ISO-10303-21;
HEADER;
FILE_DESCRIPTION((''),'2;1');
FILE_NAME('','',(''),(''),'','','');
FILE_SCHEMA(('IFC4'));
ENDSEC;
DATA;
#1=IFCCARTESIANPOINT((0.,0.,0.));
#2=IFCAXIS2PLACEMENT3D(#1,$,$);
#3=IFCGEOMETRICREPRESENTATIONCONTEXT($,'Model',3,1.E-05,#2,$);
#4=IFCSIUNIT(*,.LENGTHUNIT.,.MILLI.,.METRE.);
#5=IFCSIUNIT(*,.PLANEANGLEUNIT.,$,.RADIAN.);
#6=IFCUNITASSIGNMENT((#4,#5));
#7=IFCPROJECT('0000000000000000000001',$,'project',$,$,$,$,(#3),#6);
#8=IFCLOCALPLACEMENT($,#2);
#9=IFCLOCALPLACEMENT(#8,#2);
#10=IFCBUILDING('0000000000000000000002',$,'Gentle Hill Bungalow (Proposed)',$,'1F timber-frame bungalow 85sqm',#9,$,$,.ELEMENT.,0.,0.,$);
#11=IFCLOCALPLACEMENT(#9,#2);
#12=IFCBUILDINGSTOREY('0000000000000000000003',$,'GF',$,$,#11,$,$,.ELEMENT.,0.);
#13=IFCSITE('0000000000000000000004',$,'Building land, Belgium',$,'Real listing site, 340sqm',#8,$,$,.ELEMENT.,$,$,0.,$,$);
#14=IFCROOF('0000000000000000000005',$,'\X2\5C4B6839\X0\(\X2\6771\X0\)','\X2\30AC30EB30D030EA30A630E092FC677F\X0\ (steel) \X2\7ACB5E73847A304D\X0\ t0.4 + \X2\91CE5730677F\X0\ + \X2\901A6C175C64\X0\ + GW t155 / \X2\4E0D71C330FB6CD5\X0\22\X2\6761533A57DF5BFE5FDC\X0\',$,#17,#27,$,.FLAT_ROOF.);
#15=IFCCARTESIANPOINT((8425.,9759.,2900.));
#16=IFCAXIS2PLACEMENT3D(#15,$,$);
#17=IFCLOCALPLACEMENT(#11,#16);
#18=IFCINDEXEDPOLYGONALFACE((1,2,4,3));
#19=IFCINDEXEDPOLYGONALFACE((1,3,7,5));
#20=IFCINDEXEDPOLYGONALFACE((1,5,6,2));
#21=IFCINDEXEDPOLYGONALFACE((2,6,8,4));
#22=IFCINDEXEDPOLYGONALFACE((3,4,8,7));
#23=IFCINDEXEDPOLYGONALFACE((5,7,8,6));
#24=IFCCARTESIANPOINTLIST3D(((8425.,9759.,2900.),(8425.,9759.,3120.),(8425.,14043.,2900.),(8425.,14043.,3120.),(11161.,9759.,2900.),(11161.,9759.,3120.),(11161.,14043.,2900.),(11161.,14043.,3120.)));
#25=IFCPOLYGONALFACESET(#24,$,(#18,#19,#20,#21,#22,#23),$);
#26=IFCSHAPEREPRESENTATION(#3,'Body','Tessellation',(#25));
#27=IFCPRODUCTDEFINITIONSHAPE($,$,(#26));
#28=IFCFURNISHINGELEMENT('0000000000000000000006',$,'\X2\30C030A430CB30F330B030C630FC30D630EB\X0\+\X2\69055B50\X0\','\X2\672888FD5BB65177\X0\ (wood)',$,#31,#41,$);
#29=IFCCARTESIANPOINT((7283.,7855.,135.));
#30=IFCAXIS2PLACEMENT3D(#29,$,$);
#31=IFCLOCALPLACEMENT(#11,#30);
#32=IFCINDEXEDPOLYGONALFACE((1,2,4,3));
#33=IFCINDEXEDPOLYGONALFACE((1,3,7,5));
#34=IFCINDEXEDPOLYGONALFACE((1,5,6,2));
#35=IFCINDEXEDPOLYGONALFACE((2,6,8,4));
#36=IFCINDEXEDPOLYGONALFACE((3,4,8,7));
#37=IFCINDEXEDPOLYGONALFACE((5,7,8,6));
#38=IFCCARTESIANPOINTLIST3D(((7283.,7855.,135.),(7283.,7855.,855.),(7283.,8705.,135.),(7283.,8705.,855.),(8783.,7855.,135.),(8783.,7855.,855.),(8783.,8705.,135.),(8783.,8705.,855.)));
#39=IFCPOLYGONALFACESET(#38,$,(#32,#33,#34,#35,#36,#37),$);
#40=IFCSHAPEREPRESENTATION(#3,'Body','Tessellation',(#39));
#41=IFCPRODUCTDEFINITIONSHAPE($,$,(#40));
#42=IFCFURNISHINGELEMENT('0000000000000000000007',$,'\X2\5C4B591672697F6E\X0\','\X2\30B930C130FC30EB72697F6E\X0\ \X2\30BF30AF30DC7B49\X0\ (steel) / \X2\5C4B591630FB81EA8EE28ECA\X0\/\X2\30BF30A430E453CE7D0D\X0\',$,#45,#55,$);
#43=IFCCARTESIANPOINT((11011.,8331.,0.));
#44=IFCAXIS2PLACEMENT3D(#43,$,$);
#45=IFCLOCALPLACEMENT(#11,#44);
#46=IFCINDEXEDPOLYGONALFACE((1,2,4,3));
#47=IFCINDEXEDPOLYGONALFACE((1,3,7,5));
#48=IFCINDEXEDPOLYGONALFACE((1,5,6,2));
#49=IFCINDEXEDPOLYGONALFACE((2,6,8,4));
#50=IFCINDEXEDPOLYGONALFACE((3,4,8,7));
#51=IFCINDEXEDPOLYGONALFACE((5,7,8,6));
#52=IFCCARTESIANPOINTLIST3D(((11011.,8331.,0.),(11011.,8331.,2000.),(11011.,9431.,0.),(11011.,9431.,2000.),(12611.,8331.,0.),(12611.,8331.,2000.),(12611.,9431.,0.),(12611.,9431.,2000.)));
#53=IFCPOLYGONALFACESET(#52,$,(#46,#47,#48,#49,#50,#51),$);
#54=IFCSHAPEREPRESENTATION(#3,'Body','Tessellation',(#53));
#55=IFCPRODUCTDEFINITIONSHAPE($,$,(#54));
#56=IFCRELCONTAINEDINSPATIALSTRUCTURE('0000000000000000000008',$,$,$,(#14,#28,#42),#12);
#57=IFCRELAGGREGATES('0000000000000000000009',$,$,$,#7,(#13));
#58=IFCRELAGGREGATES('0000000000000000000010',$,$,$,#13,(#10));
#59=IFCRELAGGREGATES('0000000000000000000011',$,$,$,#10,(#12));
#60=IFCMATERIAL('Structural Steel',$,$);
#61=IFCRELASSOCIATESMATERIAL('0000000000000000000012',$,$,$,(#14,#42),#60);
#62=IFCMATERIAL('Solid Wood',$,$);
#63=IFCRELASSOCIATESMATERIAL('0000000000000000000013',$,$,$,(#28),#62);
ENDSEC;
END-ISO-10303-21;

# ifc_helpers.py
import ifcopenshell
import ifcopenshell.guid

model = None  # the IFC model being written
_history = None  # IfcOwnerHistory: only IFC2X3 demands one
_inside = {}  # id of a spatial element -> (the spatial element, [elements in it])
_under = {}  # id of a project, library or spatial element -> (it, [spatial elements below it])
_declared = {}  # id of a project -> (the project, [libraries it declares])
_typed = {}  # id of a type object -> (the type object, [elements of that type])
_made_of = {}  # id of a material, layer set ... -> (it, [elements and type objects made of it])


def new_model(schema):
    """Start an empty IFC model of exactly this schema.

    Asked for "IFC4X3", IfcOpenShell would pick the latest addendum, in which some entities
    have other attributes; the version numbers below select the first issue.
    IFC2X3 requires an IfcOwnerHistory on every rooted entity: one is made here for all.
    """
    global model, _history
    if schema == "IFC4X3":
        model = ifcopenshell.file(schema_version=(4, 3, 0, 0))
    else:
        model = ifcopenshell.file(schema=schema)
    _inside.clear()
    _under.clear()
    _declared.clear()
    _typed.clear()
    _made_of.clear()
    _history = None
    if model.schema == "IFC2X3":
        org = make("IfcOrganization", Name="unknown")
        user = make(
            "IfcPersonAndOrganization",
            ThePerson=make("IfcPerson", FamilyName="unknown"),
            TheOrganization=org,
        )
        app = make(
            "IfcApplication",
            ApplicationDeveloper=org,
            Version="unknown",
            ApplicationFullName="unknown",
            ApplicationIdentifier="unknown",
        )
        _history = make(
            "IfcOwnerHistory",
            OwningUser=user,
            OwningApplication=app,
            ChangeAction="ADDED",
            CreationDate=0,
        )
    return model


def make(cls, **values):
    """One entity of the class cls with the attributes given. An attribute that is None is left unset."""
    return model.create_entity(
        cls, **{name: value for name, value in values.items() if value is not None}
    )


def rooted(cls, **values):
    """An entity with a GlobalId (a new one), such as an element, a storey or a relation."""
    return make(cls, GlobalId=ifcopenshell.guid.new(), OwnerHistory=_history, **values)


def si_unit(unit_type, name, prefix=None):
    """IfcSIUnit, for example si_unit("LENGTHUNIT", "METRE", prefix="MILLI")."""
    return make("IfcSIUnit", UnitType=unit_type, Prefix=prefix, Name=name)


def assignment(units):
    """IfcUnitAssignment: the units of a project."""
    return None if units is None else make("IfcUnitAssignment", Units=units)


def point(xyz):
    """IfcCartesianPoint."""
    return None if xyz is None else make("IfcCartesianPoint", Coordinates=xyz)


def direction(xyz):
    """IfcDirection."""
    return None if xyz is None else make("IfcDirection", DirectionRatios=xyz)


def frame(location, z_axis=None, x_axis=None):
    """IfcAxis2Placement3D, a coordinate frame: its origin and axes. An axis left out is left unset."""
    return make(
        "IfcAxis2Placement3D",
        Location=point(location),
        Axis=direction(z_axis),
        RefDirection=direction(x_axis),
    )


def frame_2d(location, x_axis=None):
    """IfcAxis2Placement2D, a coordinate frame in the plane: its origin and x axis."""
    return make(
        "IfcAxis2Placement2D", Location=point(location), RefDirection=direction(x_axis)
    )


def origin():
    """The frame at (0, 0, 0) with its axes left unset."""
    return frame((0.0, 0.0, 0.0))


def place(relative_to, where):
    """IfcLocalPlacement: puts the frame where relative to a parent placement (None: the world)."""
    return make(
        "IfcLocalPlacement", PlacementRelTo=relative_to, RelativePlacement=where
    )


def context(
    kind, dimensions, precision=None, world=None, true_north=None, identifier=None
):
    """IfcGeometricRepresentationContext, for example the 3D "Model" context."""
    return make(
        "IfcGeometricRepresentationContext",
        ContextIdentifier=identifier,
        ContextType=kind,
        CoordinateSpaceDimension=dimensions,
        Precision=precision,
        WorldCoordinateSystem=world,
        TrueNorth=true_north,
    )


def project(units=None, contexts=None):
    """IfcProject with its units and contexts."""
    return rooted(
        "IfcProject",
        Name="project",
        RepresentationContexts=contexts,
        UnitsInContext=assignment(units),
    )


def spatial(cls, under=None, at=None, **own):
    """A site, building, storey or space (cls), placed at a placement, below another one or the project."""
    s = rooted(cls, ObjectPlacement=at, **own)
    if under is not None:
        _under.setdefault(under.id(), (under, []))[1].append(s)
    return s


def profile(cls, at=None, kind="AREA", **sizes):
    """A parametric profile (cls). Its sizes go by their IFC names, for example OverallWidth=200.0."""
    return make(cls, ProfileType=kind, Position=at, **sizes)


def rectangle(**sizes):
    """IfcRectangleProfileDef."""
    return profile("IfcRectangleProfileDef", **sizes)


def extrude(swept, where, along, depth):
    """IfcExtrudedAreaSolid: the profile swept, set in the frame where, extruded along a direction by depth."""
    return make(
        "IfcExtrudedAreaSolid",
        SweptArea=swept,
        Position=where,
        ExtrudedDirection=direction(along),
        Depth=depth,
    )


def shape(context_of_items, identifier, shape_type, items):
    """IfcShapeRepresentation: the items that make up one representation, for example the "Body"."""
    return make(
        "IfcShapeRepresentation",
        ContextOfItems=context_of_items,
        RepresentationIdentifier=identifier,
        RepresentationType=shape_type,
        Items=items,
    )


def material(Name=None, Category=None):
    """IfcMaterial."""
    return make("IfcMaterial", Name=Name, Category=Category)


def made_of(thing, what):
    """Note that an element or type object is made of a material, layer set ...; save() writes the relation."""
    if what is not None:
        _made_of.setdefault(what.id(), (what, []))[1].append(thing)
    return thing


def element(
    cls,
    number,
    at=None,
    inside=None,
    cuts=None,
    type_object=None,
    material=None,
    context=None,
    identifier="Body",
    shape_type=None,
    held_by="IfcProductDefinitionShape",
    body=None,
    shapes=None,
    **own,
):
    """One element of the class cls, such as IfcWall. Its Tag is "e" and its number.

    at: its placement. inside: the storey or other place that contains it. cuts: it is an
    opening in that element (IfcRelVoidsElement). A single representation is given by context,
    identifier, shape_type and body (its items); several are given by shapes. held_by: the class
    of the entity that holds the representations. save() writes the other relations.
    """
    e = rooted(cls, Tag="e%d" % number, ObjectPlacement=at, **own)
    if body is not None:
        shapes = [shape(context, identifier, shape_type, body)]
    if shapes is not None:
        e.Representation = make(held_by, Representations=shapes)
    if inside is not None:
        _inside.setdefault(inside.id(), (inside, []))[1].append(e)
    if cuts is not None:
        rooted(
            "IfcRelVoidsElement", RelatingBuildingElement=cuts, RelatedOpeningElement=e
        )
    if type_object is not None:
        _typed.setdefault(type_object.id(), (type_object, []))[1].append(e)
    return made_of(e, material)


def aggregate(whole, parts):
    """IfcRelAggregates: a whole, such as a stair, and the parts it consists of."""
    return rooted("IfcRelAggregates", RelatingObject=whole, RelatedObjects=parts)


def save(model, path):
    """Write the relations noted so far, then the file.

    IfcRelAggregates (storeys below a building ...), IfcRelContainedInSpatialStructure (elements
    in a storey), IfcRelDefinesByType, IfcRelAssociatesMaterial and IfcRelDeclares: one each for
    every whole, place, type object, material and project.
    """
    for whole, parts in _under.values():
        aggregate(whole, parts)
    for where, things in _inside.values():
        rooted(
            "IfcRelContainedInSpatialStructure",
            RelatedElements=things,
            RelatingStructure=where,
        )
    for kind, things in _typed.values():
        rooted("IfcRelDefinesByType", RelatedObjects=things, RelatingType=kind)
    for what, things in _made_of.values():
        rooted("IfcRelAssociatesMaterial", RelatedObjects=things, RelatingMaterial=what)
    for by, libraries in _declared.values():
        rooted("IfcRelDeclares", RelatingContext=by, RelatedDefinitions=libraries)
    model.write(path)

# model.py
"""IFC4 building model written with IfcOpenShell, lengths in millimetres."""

from ifc_helpers import new_model, si_unit, frame, frame_2d, origin, place, context, project, spatial, rectangle, extrude, material, element, save


model = new_model("IFC4")

# Units and contexts
model_context = context("Model", 3, precision=1e-05, world=origin())
ifc_project = project(units=[si_unit("LENGTHUNIT", "METRE", prefix="MILLI"), si_unit("PLANEANGLEUNIT", "RADIAN")], contexts=[model_context])

# Site, building, storey
site_placement = place(None, origin())
site = spatial("IfcSite", under=ifc_project, at=site_placement, Name="Building land, Belgium", ObjectType="Real listing site, 340sqm", CompositionType="ELEMENT", RefElevation=0.0)
building_placement = place(site_placement, origin())
building = spatial("IfcBuilding", under=site, at=building_placement, Name="Gentle Hill Bungalow (Proposed)", ObjectType="1F timber-frame bungalow 85sqm", CompositionType="ELEMENT", ElevationOfRefHeight=0.0, ElevationOfTerrain=0.0)
storey_placement = place(building_placement, origin())
storey = spatial("IfcBuildingStorey", under=building, at=storey_placement, Name="GF", CompositionType="ELEMENT", Elevation=0.0)

# Shared definitions
ifc_material_1 = material(Name="Solid Wood")

# Roof
ifc_material_2 = material(Name="Structural Steel")
roof_1_placement = place(storey_placement, frame((8425.0, 9759.0, 2900.0)))
element("IfcRoof", 1, at=roof_1_placement, inside=storey, material=ifc_material_2, Name="屋根(東)", Description="ガルバリウム鋼板 (steel) 立平葺き t0.4 + 野地板 + 通気層 + GW t155 / 不燃・法22条区域対応", PredefinedType="FLAT_ROOF", context=model_context, shape_type="SweptSolid", body=[
    extrude(rectangle(XDim=2736.0, YDim=4284.0, at=frame_2d((1368.0, 2142.0))), frame((8425.0, 9759.0, 2900.0)), (0.0, 0.0, 1.0), 220.0),
])

# Furnishing elements
furnishing_1_placement = place(storey_placement, frame((7283.0, 7855.0, 135.0)))
element("IfcFurnishingElement", 2, at=furnishing_1_placement, inside=storey, material=ifc_material_1, Name="ダイニングテーブル+椅子", Description="木製家具 (wood)", context=model_context, shape_type="SweptSolid", body=[
    extrude(rectangle(XDim=1500.0, YDim=850.0, at=frame_2d((750.0, 425.0))), frame((7283.0, 7855.0, 135.0)), (0.0, 0.0, 1.0), 720.0),
])
furnishing_2_placement = place(storey_placement, frame((11011.0, 8331.0, 0.0)))
element("IfcFurnishingElement", 3, at=furnishing_2_placement, inside=storey, material=ifc_material_2, Name="屋外物置", Description="スチール物置 タクボ等 (steel) / 屋外・自転車/タイヤ収納", context=model_context, shape_type="SweptSolid", body=[
    extrude(rectangle(XDim=1600.0, YDim=1100.0, at=frame_2d((800.0, 550.0))), frame((11011.0, 8331.0, 0.0)), (0.0, 0.0, 1.0), 2000.0),
])

save(model, "model.ifc")
